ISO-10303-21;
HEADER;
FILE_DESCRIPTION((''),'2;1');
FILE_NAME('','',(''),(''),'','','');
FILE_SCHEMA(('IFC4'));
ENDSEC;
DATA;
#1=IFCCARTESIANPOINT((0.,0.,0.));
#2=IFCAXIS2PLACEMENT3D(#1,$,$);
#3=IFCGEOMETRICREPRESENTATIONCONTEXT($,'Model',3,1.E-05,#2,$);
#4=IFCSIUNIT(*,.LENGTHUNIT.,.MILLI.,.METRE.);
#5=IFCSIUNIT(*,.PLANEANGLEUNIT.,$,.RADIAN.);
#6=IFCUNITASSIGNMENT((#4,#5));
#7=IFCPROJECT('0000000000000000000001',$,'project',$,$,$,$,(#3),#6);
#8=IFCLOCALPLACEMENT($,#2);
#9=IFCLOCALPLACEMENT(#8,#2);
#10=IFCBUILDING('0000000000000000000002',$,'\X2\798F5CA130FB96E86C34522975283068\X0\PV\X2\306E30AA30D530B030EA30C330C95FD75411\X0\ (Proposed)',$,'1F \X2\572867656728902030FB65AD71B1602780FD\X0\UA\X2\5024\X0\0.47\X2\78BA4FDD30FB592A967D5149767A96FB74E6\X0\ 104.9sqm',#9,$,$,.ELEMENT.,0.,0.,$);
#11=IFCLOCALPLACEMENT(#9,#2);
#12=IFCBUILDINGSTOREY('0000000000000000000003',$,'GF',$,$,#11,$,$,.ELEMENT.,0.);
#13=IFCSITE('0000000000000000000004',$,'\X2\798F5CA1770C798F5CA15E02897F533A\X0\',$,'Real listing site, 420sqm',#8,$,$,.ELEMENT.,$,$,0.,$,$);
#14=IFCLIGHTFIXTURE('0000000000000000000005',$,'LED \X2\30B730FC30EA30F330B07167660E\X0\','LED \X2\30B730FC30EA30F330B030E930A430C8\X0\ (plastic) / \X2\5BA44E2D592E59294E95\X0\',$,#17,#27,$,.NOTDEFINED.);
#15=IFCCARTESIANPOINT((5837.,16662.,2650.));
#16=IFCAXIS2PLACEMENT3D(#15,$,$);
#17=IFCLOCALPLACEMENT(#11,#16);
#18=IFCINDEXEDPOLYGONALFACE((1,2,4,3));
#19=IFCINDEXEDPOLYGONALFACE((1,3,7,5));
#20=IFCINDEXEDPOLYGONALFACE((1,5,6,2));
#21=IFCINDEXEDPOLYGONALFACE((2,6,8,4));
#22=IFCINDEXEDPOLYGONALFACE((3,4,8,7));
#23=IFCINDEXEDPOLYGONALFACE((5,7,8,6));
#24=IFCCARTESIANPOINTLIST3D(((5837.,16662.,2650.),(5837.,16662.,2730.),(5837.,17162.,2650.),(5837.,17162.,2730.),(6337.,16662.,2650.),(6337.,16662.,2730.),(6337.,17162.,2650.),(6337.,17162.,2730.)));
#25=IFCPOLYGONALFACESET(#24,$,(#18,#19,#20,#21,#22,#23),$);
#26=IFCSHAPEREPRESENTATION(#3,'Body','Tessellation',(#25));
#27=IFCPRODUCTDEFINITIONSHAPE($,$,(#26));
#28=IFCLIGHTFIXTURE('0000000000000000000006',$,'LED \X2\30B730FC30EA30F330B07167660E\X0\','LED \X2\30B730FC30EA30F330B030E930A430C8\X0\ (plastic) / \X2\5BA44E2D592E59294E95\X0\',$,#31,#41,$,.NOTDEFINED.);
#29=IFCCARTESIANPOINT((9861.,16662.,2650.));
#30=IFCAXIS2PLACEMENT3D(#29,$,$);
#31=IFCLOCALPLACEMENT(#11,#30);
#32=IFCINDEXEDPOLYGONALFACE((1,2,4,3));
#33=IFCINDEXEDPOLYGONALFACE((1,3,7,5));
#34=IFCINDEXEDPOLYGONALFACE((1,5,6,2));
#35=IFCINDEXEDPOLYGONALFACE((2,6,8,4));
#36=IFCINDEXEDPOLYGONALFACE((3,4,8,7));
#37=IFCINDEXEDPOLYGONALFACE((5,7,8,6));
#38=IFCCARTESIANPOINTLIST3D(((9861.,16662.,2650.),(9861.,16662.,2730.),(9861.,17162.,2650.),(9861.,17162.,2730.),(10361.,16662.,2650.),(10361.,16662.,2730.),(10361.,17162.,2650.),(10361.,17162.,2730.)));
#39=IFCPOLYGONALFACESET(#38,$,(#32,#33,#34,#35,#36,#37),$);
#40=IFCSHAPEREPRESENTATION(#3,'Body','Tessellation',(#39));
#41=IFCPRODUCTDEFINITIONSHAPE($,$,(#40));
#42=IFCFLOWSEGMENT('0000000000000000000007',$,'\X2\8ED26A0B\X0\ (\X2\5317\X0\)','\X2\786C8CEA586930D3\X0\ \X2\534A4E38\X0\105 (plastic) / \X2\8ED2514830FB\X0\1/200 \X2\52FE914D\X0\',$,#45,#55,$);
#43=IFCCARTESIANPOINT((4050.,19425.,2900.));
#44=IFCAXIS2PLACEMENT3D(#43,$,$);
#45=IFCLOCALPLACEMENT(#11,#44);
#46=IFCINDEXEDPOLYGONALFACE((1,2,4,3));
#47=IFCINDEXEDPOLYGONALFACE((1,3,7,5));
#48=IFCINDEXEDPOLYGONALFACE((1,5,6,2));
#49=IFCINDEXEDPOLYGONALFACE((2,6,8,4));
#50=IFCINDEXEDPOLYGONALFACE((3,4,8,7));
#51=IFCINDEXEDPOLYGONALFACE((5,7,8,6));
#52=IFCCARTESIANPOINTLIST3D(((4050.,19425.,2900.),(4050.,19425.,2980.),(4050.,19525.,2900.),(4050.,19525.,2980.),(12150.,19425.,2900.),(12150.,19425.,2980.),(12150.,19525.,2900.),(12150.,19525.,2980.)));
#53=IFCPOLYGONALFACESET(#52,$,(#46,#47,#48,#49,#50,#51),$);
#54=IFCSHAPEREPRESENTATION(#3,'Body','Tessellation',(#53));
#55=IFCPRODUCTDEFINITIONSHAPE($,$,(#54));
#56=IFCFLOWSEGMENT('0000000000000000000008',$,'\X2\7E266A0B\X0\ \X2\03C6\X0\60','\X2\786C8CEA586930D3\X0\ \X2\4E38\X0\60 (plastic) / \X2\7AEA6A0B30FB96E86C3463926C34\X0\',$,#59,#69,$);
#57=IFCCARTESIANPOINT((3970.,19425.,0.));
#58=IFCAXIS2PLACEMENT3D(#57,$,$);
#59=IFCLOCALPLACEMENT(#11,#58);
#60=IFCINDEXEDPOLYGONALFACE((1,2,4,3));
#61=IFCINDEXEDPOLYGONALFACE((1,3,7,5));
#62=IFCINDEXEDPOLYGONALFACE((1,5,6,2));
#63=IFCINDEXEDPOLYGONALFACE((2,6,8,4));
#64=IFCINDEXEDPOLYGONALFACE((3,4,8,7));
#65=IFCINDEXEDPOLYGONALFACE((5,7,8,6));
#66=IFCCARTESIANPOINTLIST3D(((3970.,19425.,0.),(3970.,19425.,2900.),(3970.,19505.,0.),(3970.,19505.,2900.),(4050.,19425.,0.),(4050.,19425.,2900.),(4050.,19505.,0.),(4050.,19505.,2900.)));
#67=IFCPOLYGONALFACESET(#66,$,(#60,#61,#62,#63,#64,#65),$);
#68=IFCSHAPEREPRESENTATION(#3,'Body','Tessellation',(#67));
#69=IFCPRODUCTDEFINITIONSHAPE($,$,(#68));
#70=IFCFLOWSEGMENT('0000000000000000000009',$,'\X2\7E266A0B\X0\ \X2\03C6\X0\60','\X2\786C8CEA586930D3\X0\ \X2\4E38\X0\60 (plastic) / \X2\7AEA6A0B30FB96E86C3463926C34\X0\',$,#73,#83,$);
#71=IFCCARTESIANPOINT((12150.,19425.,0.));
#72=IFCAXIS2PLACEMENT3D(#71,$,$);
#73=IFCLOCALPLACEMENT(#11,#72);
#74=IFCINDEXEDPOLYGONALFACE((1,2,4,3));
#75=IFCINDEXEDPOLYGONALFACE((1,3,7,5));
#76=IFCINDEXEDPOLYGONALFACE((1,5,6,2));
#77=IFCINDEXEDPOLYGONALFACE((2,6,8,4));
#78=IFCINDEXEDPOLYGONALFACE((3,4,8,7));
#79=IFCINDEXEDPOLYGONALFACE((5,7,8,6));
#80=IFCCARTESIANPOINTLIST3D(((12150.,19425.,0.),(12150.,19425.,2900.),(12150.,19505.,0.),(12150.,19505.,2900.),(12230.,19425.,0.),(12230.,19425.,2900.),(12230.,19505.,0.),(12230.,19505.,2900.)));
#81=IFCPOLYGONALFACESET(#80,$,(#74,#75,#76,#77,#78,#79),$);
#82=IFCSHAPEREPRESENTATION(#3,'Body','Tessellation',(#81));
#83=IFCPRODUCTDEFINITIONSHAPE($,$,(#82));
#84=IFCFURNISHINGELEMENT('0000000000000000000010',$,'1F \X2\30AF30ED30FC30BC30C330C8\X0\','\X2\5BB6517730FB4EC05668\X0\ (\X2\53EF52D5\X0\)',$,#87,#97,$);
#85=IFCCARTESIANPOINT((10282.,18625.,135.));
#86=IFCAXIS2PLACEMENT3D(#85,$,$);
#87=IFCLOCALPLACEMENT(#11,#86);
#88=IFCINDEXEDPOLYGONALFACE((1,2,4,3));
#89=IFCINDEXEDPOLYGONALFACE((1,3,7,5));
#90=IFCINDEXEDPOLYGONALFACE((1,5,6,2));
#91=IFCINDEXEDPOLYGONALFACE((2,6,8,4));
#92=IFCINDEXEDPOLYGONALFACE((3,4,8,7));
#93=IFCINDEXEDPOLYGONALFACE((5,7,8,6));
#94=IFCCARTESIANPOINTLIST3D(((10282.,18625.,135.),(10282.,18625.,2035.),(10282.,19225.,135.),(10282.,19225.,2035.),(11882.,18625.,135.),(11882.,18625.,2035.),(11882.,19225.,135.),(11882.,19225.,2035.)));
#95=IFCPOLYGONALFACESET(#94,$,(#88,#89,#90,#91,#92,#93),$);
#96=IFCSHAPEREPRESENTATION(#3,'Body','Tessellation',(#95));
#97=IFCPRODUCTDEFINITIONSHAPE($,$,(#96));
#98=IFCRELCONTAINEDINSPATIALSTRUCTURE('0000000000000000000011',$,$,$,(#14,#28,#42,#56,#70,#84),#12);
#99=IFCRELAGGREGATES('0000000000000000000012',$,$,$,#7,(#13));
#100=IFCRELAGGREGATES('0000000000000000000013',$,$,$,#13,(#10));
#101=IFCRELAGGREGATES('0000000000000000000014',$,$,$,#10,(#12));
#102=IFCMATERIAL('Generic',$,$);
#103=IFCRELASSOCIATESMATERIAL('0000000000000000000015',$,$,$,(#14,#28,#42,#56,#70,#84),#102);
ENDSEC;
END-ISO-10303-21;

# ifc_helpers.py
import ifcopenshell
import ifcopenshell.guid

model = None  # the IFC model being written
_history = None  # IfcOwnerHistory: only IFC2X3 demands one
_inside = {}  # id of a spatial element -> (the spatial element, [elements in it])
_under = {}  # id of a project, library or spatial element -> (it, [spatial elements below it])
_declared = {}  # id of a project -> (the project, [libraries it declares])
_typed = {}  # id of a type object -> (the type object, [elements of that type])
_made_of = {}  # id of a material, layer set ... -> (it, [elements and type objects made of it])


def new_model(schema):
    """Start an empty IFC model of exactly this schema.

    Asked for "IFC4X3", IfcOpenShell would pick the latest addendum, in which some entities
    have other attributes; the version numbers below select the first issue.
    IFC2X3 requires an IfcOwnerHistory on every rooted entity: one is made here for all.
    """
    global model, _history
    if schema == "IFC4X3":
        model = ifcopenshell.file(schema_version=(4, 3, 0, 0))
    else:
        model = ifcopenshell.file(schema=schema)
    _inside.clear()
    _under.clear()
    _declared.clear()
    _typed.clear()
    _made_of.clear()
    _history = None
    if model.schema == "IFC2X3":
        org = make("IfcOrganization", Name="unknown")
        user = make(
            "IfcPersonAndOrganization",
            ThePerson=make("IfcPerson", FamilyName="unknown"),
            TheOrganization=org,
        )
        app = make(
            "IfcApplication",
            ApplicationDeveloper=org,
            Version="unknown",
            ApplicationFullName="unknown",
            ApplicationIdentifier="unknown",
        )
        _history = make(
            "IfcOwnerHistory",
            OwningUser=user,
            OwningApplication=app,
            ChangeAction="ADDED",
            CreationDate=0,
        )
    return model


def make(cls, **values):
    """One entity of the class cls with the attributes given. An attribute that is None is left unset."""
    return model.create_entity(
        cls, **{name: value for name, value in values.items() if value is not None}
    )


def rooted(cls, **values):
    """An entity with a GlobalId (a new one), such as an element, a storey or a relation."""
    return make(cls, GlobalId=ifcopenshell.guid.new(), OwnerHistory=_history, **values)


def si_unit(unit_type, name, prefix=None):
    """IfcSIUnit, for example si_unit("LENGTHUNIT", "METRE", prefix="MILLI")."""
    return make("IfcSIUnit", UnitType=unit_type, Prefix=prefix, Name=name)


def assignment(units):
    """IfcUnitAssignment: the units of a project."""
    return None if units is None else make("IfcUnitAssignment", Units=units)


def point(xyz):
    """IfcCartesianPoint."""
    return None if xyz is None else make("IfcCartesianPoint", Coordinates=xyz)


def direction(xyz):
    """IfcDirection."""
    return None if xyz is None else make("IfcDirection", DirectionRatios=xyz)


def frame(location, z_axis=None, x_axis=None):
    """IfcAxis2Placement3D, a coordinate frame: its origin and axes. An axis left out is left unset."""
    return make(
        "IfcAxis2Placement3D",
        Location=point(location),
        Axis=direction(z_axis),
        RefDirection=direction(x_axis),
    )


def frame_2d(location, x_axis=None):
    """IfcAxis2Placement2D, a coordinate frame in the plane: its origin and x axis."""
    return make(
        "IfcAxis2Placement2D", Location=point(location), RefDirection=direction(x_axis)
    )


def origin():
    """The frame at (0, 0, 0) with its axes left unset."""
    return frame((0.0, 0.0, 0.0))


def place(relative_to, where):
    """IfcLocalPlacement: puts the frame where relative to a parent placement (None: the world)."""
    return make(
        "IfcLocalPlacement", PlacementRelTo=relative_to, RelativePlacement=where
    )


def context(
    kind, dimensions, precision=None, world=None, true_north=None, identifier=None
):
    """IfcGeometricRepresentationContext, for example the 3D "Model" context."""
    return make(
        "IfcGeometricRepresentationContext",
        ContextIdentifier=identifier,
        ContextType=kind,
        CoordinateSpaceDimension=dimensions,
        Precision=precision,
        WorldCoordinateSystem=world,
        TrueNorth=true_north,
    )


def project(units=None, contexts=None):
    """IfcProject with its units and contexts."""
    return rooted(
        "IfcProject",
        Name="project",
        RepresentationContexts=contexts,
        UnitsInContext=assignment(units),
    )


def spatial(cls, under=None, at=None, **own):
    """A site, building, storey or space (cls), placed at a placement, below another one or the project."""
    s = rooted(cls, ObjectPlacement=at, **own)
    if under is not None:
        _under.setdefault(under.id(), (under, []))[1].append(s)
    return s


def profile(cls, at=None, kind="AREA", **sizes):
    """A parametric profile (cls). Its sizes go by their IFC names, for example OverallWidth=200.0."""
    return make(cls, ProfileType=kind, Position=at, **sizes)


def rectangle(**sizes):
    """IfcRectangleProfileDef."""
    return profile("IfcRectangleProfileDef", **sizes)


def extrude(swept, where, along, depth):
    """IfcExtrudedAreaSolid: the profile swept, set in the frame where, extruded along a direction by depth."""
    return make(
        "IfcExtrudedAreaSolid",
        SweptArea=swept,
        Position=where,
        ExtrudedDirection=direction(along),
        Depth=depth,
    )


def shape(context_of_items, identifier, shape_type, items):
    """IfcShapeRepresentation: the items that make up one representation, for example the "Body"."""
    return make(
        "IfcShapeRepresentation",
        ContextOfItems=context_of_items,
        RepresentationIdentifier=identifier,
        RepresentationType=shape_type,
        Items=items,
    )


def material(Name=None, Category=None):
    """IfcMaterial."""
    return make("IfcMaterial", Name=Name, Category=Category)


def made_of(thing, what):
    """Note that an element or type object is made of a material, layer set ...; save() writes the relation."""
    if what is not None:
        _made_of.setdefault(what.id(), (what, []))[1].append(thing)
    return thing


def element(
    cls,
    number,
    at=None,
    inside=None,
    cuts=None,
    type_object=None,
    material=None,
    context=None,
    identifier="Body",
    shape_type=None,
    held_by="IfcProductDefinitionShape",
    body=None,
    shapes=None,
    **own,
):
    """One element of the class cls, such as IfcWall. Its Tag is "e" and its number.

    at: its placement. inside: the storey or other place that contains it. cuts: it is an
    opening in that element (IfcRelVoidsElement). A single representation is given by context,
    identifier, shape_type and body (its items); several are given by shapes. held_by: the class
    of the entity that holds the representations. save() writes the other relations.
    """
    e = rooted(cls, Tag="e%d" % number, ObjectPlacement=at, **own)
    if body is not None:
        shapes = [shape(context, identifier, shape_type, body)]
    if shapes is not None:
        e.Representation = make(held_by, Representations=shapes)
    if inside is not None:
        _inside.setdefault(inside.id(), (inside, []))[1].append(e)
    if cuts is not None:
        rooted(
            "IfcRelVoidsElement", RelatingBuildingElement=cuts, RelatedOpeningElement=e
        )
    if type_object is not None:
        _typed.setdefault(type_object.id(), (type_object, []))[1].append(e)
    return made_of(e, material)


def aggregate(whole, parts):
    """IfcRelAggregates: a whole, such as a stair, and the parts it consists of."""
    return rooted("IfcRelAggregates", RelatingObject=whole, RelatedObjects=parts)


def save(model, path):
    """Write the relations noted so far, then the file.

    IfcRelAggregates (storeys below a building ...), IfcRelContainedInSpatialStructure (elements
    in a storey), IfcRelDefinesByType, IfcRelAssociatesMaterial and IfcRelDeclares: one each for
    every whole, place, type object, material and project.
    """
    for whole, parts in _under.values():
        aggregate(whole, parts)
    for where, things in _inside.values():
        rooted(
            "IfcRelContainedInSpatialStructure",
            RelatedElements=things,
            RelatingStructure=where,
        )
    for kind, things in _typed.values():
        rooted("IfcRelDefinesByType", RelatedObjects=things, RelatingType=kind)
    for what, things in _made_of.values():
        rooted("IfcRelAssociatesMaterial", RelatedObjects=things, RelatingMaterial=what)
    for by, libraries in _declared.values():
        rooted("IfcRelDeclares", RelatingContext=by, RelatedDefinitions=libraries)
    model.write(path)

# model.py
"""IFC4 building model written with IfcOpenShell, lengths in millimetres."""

from ifc_helpers import new_model, si_unit, frame, frame_2d, origin, place, context, project, spatial, rectangle, extrude, material, element, save


model = new_model("IFC4")

# Units and contexts
model_context = context("Model", 3, precision=1e-05, world=origin())
ifc_project = project(units=[si_unit("LENGTHUNIT", "METRE", prefix="MILLI"), si_unit("PLANEANGLEUNIT", "RADIAN")], contexts=[model_context])

# Site, building, storey
site_placement = place(None, origin())
site = spatial("IfcSite", under=ifc_project, at=site_placement, Name="福岡県福岡市西区", ObjectType="Real listing site, 420sqm", CompositionType="ELEMENT", RefElevation=0.0)
building_placement = place(site_placement, origin())
building = spatial("IfcBuilding", under=site, at=building_placement, Name="福岡・雨水利用とPVのオフグリッド志向 (Proposed)", ObjectType="1F 在来木造・断熱性能UA値0.47確保・太陽光発電瓦 104.9sqm", CompositionType="ELEMENT", ElevationOfRefHeight=0.0, ElevationOfTerrain=0.0)
storey_placement = place(building_placement, origin())
storey = spatial("IfcBuildingStorey", under=building, at=storey_placement, Name="GF", CompositionType="ELEMENT", Elevation=0.0)

# Shared definitions
ifc_material_1 = material(Name="Generic")

# Light fixtures
light_fixture_1_placement = place(storey_placement, frame((5837.0, 16662.0, 2650.0)))
element("IfcLightFixture", 1, at=light_fixture_1_placement, inside=storey, material=ifc_material_1, Name="LED シーリング照明", Description="LED シーリングライト (plastic) / 室中央天井", PredefinedType="NOTDEFINED", context=model_context, shape_type="SweptSolid", body=[
    extrude(rectangle(XDim=500.0, YDim=500.0, at=frame_2d((250.0, 250.0))), frame((5837.0, 16662.0, 2650.0)), (0.0, 0.0, 1.0), 80.0),
])
light_fixture_2_placement = place(storey_placement, frame((9861.0, 16662.0, 2650.0)))
element("IfcLightFixture", 2, at=light_fixture_2_placement, inside=storey, material=ifc_material_1, Name="LED シーリング照明", Description="LED シーリングライト (plastic) / 室中央天井", PredefinedType="NOTDEFINED", context=model_context, shape_type="SweptSolid", body=[
    extrude(rectangle(XDim=500.0, YDim=500.0, at=frame_2d((250.0, 250.0))), frame((9861.0, 16662.0, 2650.0)), (0.0, 0.0, 1.0), 80.0),
])

# Flow segments
flow_segment_1_placement = place(storey_placement, frame((4050.0, 19425.0, 2900.0)))
element("IfcFlowSegment", 3, at=flow_segment_1_placement, inside=storey, material=ifc_material_1, Name="軒樋 (北)", Description="硬質塩ビ 半丸105 (plastic) / 軒先・1/200 勾配", context=model_context, shape_type="SweptSolid", body=[
    extrude(rectangle(XDim=8100.0, YDim=100.0, at=frame_2d((4050.0, 50.0))), frame((4050.0, 19425.0, 2900.0)), (0.0, 0.0, 1.0), 80.0),
])
flow_segment_2_placement = place(storey_placement, frame((3970.0, 19425.0, 0.0)))
element("IfcFlowSegment", 4, at=flow_segment_2_placement, inside=storey, material=ifc_material_1, Name="縦樋 φ60", Description="硬質塩ビ 丸60 (plastic) / 竪樋・雨水排水", context=model_context, shape_type="SweptSolid", body=[
    extrude(rectangle(XDim=80.0, YDim=80.0, at=frame_2d((40.0, 40.0))), frame((3970.0, 19425.0, 0.0)), (0.0, 0.0, 1.0), 2900.0),
])
flow_segment_3_placement = place(storey_placement, frame((12150.0, 19425.0, 0.0)))
element("IfcFlowSegment", 5, at=flow_segment_3_placement, inside=storey, material=ifc_material_1, Name="縦樋 φ60", Description="硬質塩ビ 丸60 (plastic) / 竪樋・雨水排水", context=model_context, shape_type="SweptSolid", body=[
    extrude(rectangle(XDim=80.0, YDim=80.0, at=frame_2d((40.0, 40.0))), frame((12150.0, 19425.0, 0.0)), (0.0, 0.0, 1.0), 2900.0),
])

# Furnishing element
furnishing_placement = place(storey_placement, frame((10282.0, 18625.0, 135.0)))
element("IfcFurnishingElement", 6, at=furnishing_placement, inside=storey, material=ifc_material_1, Name="1F クローゼット", Description="家具・什器 (可動)", context=model_context, shape_type="SweptSolid", body=[
    extrude(rectangle(XDim=1600.0, YDim=600.0, at=frame_2d((800.0, 300.0))), frame((10282.0, 18625.0, 135.0)), (0.0, 0.0, 1.0), 1900.0),
])

save(model, "model.ifc")
